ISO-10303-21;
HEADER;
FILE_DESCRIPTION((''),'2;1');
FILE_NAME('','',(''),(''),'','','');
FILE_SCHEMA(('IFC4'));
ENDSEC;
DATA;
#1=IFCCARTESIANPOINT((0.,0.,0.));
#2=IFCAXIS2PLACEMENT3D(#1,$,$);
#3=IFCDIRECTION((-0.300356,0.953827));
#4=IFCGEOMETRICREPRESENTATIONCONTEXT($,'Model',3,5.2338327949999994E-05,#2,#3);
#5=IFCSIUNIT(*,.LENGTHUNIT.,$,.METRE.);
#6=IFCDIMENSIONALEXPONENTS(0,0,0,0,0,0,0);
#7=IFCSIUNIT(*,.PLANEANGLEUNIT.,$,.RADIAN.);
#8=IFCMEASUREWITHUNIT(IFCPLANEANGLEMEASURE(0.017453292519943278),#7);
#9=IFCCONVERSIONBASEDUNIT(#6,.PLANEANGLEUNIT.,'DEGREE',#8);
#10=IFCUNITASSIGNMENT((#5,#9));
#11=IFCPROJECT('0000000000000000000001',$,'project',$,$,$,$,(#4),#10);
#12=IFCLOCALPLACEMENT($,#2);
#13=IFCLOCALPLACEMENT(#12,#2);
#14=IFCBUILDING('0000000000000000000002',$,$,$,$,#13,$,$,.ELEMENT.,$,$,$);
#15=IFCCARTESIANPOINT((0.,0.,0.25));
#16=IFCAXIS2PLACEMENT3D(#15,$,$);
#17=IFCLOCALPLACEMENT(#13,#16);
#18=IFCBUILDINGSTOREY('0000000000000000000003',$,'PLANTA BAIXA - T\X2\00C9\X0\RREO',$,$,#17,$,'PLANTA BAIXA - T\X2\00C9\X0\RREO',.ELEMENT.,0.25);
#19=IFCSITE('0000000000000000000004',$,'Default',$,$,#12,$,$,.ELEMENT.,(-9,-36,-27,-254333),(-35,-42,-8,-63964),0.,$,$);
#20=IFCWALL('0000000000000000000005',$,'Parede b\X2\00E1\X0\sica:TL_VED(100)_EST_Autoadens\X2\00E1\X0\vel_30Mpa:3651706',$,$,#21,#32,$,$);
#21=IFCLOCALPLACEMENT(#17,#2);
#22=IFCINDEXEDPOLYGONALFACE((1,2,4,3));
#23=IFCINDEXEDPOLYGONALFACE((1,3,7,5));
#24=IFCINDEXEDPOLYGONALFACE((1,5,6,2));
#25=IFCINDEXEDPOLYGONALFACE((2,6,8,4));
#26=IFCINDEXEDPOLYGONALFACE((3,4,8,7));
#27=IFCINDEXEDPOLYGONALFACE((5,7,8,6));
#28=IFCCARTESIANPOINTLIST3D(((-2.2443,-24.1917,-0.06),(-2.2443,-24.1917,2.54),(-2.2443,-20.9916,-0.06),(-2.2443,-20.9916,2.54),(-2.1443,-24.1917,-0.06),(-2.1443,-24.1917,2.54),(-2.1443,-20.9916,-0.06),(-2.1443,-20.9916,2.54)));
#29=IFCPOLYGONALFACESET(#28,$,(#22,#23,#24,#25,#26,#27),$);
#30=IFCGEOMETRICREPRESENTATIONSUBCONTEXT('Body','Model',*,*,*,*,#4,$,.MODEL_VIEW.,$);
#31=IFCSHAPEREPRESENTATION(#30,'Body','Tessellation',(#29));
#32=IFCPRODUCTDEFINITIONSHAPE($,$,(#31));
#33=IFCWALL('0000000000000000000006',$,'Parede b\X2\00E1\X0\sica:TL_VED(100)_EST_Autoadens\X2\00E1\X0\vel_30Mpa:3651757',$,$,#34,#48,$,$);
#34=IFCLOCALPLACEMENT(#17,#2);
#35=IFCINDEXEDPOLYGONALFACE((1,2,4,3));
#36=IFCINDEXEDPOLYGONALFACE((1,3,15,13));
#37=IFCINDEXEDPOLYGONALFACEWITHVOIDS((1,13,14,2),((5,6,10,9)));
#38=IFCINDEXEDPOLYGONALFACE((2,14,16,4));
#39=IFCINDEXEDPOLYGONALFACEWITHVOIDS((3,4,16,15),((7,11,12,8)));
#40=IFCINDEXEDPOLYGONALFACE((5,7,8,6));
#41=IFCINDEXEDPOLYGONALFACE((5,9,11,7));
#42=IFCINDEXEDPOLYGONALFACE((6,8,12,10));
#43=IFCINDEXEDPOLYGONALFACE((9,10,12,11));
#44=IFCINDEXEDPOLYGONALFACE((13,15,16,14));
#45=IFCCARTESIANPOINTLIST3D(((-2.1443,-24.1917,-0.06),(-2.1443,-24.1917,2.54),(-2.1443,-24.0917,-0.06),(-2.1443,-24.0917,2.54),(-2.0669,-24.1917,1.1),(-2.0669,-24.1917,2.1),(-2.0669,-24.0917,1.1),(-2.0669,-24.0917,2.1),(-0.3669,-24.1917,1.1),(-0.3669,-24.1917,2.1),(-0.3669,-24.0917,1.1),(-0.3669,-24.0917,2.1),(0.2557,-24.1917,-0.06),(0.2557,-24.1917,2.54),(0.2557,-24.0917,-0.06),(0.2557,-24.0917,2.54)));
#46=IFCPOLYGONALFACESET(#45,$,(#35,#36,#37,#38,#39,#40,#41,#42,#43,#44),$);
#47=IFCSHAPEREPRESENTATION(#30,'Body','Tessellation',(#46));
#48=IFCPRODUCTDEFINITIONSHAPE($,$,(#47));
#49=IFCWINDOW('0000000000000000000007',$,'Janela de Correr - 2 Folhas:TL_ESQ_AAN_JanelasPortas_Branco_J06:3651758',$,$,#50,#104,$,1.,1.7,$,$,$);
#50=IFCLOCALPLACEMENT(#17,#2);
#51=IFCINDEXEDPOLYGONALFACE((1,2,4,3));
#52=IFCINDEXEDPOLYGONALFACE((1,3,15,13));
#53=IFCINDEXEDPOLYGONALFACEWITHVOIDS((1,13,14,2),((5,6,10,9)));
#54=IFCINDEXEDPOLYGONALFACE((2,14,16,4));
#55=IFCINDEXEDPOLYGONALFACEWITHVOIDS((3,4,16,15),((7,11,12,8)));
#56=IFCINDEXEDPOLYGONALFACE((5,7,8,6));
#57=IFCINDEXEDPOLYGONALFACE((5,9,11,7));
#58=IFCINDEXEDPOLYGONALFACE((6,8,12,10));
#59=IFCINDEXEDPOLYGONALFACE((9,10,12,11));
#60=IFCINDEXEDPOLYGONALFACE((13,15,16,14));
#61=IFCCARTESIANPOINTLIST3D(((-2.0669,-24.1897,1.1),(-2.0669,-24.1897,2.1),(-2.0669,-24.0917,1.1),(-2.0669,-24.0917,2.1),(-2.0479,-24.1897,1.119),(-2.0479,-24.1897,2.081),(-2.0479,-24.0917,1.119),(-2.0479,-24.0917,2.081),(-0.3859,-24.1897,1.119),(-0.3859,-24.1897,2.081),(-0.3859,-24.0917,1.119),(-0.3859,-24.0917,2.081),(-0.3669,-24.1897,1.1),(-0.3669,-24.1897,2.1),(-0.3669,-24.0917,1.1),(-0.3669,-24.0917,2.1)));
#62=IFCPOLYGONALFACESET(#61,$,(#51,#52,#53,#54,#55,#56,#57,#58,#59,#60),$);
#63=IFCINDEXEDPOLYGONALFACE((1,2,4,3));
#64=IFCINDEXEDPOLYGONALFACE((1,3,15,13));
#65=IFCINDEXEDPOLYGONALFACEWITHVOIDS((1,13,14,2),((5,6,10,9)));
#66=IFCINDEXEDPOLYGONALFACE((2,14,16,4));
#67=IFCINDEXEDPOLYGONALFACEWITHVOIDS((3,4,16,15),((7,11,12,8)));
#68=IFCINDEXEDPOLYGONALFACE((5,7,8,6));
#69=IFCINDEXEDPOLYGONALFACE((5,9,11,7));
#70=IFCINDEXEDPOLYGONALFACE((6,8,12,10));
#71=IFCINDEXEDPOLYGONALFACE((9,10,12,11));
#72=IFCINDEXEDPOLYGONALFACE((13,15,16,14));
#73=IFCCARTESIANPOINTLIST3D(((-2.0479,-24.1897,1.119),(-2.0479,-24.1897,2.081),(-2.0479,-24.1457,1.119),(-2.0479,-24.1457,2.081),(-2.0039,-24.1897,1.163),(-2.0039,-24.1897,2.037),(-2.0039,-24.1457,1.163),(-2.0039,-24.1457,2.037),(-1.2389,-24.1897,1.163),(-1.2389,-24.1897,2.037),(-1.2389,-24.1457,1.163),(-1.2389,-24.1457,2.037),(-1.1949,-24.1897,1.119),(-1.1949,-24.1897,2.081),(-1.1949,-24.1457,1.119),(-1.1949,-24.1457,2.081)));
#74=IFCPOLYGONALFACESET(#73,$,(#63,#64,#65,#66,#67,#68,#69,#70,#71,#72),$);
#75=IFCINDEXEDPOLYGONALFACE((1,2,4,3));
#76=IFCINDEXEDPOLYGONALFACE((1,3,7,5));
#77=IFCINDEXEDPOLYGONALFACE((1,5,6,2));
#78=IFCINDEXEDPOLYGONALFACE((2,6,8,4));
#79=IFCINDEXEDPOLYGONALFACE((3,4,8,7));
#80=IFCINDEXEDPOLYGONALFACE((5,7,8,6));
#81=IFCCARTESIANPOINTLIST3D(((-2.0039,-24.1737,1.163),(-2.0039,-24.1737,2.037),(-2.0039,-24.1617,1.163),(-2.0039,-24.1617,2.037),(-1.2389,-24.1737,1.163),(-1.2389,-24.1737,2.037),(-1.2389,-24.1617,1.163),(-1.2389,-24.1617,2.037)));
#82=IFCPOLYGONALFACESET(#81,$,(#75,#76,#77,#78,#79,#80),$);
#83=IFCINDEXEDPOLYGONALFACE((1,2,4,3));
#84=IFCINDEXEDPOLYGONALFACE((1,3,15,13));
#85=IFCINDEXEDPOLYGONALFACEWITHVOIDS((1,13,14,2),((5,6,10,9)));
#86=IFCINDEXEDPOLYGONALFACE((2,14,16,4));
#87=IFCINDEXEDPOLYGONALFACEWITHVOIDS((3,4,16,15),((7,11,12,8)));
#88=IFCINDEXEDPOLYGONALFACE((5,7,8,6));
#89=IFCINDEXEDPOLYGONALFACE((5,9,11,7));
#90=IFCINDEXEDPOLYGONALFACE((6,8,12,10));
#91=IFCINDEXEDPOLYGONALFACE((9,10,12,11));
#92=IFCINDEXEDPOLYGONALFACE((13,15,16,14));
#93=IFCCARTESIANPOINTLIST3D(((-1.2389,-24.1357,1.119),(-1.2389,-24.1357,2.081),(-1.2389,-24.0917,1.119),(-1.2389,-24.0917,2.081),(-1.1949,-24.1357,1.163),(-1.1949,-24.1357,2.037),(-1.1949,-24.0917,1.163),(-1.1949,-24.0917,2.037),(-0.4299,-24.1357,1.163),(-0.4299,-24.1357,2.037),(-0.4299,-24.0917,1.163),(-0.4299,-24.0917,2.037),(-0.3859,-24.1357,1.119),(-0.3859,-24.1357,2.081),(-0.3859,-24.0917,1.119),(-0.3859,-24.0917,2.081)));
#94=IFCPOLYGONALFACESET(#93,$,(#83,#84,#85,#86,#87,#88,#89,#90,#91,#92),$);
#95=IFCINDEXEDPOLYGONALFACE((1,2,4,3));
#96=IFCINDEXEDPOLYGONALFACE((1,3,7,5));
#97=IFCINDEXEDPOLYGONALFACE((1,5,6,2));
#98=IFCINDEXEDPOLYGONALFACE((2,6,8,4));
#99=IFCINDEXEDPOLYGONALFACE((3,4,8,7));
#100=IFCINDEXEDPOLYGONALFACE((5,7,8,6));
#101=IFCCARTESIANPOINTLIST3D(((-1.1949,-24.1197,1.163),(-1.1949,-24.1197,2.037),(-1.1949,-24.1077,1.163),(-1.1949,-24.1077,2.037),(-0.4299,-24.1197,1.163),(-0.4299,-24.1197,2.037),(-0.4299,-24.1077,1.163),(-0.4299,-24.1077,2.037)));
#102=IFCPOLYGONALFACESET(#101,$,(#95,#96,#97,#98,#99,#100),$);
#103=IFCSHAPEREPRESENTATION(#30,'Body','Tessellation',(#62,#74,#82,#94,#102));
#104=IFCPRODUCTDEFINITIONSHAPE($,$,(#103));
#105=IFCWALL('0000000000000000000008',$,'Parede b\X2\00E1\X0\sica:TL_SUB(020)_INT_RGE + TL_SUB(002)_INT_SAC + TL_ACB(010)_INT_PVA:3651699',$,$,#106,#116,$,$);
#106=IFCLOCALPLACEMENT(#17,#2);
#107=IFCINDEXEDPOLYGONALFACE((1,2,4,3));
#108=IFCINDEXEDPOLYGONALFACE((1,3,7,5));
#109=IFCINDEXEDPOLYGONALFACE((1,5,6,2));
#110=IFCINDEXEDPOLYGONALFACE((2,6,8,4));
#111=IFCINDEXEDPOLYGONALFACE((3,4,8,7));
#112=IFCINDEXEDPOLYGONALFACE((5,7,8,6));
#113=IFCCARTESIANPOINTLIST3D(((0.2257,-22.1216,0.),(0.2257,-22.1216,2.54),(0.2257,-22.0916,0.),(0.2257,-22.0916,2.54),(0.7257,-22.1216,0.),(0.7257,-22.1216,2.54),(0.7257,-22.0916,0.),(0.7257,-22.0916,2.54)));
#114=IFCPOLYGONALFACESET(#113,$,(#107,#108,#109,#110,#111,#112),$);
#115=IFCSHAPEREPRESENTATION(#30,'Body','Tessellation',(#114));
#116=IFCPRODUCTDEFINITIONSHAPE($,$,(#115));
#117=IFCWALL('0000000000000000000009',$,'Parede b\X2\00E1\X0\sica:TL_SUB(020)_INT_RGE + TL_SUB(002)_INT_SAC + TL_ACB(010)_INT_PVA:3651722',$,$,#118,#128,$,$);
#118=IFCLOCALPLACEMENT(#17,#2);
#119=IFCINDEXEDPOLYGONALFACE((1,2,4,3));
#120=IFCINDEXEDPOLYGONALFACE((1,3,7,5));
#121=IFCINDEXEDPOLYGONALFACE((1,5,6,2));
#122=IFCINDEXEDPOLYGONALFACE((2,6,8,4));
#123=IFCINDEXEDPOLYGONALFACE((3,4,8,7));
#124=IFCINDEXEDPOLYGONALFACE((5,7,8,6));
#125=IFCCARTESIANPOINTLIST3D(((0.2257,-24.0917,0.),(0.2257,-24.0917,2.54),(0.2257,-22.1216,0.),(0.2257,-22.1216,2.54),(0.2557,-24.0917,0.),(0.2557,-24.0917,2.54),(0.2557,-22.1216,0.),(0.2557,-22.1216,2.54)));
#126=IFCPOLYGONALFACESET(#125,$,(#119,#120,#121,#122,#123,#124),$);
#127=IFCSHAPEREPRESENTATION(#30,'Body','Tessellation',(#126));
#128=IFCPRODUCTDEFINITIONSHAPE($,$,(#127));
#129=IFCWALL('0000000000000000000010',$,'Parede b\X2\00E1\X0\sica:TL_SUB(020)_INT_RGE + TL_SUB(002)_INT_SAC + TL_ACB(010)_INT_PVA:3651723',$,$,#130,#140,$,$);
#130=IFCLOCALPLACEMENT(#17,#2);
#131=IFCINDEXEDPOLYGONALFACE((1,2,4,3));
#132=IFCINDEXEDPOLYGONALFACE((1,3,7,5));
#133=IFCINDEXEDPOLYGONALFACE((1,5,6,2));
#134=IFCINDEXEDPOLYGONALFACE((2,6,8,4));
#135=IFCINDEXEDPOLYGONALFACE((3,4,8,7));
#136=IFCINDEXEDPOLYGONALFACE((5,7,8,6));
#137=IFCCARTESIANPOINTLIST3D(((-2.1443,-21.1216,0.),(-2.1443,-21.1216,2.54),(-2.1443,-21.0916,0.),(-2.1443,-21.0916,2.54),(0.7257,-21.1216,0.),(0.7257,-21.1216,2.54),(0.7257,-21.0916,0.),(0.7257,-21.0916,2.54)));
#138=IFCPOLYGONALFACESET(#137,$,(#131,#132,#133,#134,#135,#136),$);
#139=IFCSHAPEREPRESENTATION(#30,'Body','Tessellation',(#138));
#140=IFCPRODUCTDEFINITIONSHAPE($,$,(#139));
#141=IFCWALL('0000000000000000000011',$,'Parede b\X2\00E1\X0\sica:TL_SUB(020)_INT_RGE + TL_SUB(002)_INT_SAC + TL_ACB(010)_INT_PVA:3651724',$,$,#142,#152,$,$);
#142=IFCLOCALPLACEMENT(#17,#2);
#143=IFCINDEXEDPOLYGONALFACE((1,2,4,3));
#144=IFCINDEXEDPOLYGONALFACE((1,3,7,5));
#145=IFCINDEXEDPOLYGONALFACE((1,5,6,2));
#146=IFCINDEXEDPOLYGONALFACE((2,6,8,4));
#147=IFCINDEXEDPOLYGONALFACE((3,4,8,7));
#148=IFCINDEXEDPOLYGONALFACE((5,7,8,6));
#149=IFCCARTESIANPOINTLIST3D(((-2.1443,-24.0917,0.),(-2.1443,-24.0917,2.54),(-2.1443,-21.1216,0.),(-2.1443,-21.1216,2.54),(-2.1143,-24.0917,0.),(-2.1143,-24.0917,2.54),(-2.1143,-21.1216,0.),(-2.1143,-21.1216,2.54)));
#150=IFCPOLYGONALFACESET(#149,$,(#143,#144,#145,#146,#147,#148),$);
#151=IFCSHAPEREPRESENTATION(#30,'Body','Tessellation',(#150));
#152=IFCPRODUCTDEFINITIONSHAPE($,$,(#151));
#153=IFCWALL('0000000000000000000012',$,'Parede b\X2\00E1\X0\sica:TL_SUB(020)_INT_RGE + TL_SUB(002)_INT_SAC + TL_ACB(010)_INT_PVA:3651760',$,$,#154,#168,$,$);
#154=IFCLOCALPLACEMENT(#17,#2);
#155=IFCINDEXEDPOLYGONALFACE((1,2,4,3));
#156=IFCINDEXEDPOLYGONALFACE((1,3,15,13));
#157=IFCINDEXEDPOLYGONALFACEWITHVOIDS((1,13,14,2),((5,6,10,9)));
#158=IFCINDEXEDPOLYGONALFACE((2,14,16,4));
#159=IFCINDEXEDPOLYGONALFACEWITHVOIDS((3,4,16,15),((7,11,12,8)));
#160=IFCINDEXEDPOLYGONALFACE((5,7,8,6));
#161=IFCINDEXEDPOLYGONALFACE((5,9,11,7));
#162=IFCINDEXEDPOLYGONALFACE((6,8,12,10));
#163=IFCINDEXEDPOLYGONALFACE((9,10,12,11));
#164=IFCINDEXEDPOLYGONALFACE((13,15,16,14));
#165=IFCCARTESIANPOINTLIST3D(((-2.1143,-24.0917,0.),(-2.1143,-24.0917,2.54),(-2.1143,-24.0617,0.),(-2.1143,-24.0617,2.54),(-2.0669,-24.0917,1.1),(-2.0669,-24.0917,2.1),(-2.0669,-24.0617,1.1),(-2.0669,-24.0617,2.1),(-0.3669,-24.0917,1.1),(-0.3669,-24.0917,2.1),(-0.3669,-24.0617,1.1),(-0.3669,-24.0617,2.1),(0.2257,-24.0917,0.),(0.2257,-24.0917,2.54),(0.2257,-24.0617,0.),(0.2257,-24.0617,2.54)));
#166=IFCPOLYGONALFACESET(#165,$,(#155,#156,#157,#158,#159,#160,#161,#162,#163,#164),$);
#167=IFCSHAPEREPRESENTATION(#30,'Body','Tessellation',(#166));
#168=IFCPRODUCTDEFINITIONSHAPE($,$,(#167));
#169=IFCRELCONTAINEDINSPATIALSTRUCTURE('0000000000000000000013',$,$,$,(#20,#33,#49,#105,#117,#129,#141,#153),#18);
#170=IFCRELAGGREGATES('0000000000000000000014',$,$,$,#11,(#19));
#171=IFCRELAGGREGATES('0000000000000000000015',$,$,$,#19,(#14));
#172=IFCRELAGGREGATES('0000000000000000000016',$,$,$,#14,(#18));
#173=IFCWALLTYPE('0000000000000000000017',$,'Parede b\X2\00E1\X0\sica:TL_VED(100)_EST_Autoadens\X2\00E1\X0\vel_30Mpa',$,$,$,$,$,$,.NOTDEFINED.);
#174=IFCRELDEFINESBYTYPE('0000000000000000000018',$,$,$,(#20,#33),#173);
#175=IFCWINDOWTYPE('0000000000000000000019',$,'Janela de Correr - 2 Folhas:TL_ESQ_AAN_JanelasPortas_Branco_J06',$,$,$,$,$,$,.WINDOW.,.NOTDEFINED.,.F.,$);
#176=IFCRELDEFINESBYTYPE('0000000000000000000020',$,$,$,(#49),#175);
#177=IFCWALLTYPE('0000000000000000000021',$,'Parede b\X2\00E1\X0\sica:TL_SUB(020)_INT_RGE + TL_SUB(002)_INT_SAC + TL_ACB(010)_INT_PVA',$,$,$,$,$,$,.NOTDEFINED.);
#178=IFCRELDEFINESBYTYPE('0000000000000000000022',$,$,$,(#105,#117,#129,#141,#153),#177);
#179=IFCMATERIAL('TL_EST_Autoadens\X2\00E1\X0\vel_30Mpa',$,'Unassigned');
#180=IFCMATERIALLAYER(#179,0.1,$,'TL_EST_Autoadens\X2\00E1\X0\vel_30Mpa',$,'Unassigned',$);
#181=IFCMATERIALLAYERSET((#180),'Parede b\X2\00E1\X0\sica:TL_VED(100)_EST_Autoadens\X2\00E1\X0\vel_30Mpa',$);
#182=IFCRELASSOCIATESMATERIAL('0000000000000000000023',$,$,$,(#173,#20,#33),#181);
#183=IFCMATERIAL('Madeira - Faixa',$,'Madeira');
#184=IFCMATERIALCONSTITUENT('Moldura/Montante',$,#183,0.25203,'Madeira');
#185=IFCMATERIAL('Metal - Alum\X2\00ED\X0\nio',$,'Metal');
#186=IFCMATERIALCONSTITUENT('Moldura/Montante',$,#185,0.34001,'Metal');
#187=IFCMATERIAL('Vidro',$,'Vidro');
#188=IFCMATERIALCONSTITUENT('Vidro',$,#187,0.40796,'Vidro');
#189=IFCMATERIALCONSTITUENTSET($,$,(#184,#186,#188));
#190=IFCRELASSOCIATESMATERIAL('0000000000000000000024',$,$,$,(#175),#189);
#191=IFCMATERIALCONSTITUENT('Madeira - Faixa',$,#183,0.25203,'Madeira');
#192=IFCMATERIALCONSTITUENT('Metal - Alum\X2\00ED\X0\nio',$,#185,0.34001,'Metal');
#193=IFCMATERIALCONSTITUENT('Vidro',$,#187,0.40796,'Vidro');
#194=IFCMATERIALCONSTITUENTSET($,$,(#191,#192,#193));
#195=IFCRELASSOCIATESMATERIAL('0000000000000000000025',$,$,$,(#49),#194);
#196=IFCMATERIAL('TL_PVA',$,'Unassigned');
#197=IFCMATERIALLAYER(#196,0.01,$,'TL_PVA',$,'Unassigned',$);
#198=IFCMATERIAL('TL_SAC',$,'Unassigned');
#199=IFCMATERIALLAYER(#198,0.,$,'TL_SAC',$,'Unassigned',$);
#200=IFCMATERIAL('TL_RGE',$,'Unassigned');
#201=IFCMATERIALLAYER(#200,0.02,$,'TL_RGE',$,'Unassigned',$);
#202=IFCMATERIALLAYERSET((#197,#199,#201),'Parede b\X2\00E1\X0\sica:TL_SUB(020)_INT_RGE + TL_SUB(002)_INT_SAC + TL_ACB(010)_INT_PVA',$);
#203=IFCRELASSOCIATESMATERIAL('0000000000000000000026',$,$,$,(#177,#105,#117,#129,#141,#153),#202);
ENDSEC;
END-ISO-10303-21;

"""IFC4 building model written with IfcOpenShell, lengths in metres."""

from ifc_helpers import new_model, entity, si_unit, converted_unit, direction, frame, frame_2d, origin, origin_2d_with_axis, place, context, subcontext, project, spatial, polyline, rectangle, outline, extrude, source, transform, mapped, material, layer, layer_set, layer_usage, constituent, constituent_set, type_object, type_shapes, element, fill, save


model = new_model("IFC4")

# Units and contexts
model_context = context("Model", 3, precision=5.2338327949999994e-05, world=origin(), true_north=direction((-0.300356, 0.953827)))
body_context = subcontext(model_context, "Body", "Model", "MODEL_VIEW")
ifc_project = project(units=[si_unit("LENGTHUNIT", "METRE"), converted_unit("PLANEANGLEUNIT", "DEGREE", entity("IfcPlaneAngleMeasure", 0.017453292519943278), si_unit("PLANEANGLEUNIT", "RADIAN"), dimensions=[0, 0, 0, 0, 0, 0, 0])], contexts=[model_context])

# Site, building, storey
site_placement = place(None, origin())
site = spatial("IfcSite", under=ifc_project, at=site_placement, Name="Default", CompositionType="ELEMENT", RefLatitude=(-9, -36, -27, -254333), RefLongitude=(-35, -42, -8, -63964), RefElevation=0.0)
building_placement = place(site_placement, origin())
building = spatial("IfcBuilding", under=site, at=building_placement, CompositionType="ELEMENT")
storey_placement = place(building_placement, frame((0.0, 0.0, 0.25)))
storey = spatial("IfcBuildingStorey", under=building, at=storey_placement, Name="PLANTA BAIXA - TÉRREO", LongName="PLANTA BAIXA - TÉRREO", CompositionType="ELEMENT", Elevation=0.25)

# Wall
ifc_material_1 = material(Name="TL_EST_Autoadensável_30Mpa", Category="Unassigned")
ifc_layer_1 = layer(ifc_material_1, 0.1, Name="TL_EST_Autoadensável_30Mpa", Category="Unassigned")
ifc_layer_set_1 = layer_set([ifc_layer_1], Name="Parede básica:TL_VED(100)_EST_Autoadensável_30Mpa")
ifc_layer_usage_1 = layer_usage(ifc_layer_set_1, "AXIS2", "POSITIVE", -0.05)
wall_type_1 = type_object("IfcWallType", Name="Parede básica:TL_VED(100)_EST_Autoadensável_30Mpa", PredefinedType="NOTDEFINED", material=ifc_layer_set_1)
wall_1_placement = place(storey_placement, frame((-2.1943, -24.1917, -0.06), z_axis=(0.0, 0.0, 1.0), x_axis=(0.0, 1.0, 0.0)))
element("IfcWall", 1, at=wall_1_placement, inside=storey, type_object=wall_type_1, material=ifc_layer_usage_1, Name="Parede básica:TL_VED(100)_EST_Autoadensável_30Mpa:3651706", context=body_context, shape_type="SweptSolid", body=[
    extrude(rectangle(XDim=3.2001, YDim=0.1, at=frame_2d((1.6001, 0.0), x_axis=(-1.0, 0.0))), origin(), (0.0, 0.0, 1.0), 2.6),
])

# Wall, opening, window
ifc_layer_usage_2 = layer_usage(ifc_layer_set_1, "AXIS2", "POSITIVE", -0.05)
wall_2_placement = place(storey_placement, frame((-2.1443, -24.1417, -0.06)))
wall_2 = element("IfcWall", 2, at=wall_2_placement, inside=storey, type_object=wall_type_1, material=ifc_layer_usage_2, Name="Parede básica:TL_VED(100)_EST_Autoadensável_30Mpa:3651757", context=body_context, shape_type="SweptSolid", body=[
    extrude(rectangle(XDim=2.4, YDim=0.1, at=frame_2d((1.2, 0.0), x_axis=(-1.0, 0.0))), origin(), (0.0, 0.0, 1.0), 2.6),
])
opening_1_placement = place(wall_2_placement, frame((1.7774, 0.05, 1.16)))
opening_1 = element("IfcOpeningElement", 3, at=opening_1_placement, cuts=wall_2, PredefinedType="OPENING", context=body_context, shape_type="SweptSolid", body=[
    extrude(rectangle(XDim=1.0, YDim=1.7, at=frame_2d((0.5, 0.85), x_axis=(-1.0, 0.0))), frame((0.0, 0.0, 0.0), z_axis=(0.0, -1.0, 0.0), x_axis=(0.0, 0.0, 1.0)), (0.0, 0.0, 1.0), 0.1),
])
ifc_material_2 = material(Name="Madeira - Faixa", Category="Madeira")
ifc_constituent_1 = constituent(ifc_material_2, Name="Madeira - Faixa", Category="Madeira", fraction=0.25203)
ifc_material_3 = material(Name="Metal - Alumínio", Category="Metal")
ifc_constituent_2 = constituent(ifc_material_3, Name="Metal - Alumínio", Category="Metal", fraction=0.34001)
ifc_material_4 = material(Name="Vidro", Category="Vidro")
ifc_constituent_3 = constituent(ifc_material_4, Name="Vidro", Category="Vidro", fraction=0.40796)
ifc_constituent_set_1 = constituent_set(constituents=[ifc_constituent_1, ifc_constituent_2, ifc_constituent_3])
ifc_constituent_4 = constituent(ifc_material_2, Name="Moldura/Montante", Category="Madeira", fraction=0.25203)
ifc_constituent_5 = constituent(ifc_material_3, Name="Moldura/Montante", Category="Metal", fraction=0.34001)
ifc_constituent_6 = constituent(ifc_material_4, Name="Vidro", Category="Vidro", fraction=0.40796)
ifc_constituent_set_2 = constituent_set(constituents=[ifc_constituent_4, ifc_constituent_5, ifc_constituent_6])
window_type = type_object("IfcWindowType", Name="Janela de Correr - 2 Folhas:TL_ESQ_AAN_JanelasPortas_Branco_J06", ParameterTakesPrecedence=False, PartitioningType="NOTDEFINED", PredefinedType="WINDOW", material=ifc_constituent_set_2)
shared_shape_1 = source(origin(), body_context, "Body", "SweptSolid", [
    extrude(outline(polyline([(-0.85, -0.5), (0.85, -0.5), (0.85, 0.5), (-0.85, 0.5), (-0.85, -0.5)]), holes=[polyline([(-0.831, -0.481), (-0.831, 0.481), (0.831, 0.481), (0.831, -0.481), (-0.831, -0.481)])]), frame((0.85, 0.0, 0.5), z_axis=(0.0, 1.0, 0.0), x_axis=(1.0, 0.0, 0.0)), (0.0, 0.0, 1.0), 0.098),
    extrude(outline(polyline([(-0.4265, -0.481), (0.4265, -0.481), (0.4265, 0.481), (-0.4265, 0.481), (-0.4265, -0.481)]), holes=[polyline([(-0.3825, -0.437), (-0.3825, 0.437), (0.3825, 0.437), (0.3825, -0.437), (-0.3825, -0.437)])]), frame((1.2545, 0.054, 0.5), z_axis=(0.0, 1.0, 0.0), x_axis=(1.0, 0.0, 0.0)), (0.0, 0.0, 1.0), 0.044),
    extrude(rectangle(XDim=0.012, YDim=0.765, at=origin_2d_with_axis()), frame((1.2545, 0.076, 0.063), z_axis=(0.0, 0.0, 1.0), x_axis=(0.0, -1.0, 0.0)), (0.0, 0.0, 1.0), 0.874),
    extrude(outline(polyline([(-0.481, -0.4265), (0.481, -0.4265), (0.481, 0.4265), (-0.481, 0.4265), (-0.481, -0.4265)]), holes=[polyline([(-0.437, -0.3825), (-0.437, 0.3825), (0.437, 0.3825), (0.437, -0.3825), (-0.437, -0.3825)])]), frame((0.4455, 0.0, 0.5), z_axis=(0.0, 1.0, 0.0), x_axis=(0.0, 0.0, -1.0)), (0.0, 0.0, 1.0), 0.044),
    extrude(rectangle(XDim=0.012, YDim=0.765, at=origin_2d_with_axis()), frame((0.4455, 0.022, 0.063), z_axis=(0.0, 0.0, 1.0), x_axis=(0.0, -1.0, 0.0)), (0.0, 0.0, 1.0), 0.874),
])
type_shapes(window_type, [shared_shape_1])
window_placement = place(opening_1_placement, frame((0.0, 0.0, 0.0), z_axis=(0.0, 0.0, 1.0), x_axis=(-1.0, 0.0, 0.0)))
window = element("IfcWindow", 4, at=window_placement, inside=storey, type_object=window_type, material=ifc_constituent_set_1, Name="Janela de Correr - 2 Folhas:TL_ESQ_AAN_JanelasPortas_Branco_J06:3651758", OverallHeight=1.0, OverallWidth=1.7, context=body_context, shape_type="MappedRepresentation", body=[
    mapped(shared_shape_1, transform((0.0, 0.0, 0.0), scale=1.0)),
])
fill(opening_1, window)

# Walls
ifc_material_5 = material(Name="TL_PVA", Category="Unassigned")
ifc_layer_2 = layer(ifc_material_5, 0.01, Name="TL_PVA", Category="Unassigned")
ifc_material_6 = material(Name="TL_SAC", Category="Unassigned")
ifc_layer_3 = layer(ifc_material_6, 0.0, Name="TL_SAC", Category="Unassigned")
ifc_material_7 = material(Name="TL_RGE", Category="Unassigned")
ifc_layer_4 = layer(ifc_material_7, 0.02, Name="TL_RGE", Category="Unassigned")
ifc_layer_set_2 = layer_set([ifc_layer_2, ifc_layer_3, ifc_layer_4], Name="Parede básica:TL_SUB(020)_INT_RGE + TL_SUB(002)_INT_SAC + TL_ACB(010)_INT_PVA")
ifc_layer_usage_3 = layer_usage(ifc_layer_set_2, "AXIS2", "NEGATIVE", 0.015)
wall_type_2 = type_object("IfcWallType", Name="Parede básica:TL_SUB(020)_INT_RGE + TL_SUB(002)_INT_SAC + TL_ACB(010)_INT_PVA", PredefinedType="NOTDEFINED", material=ifc_layer_set_2)
wall_3_placement = place(storey_placement, frame((0.2257, -22.1066, 0.0)))
element("IfcWall", 5, at=wall_3_placement, inside=storey, type_object=wall_type_2, material=ifc_layer_usage_3, Name="Parede básica:TL_SUB(020)_INT_RGE + TL_SUB(002)_INT_SAC + TL_ACB(010)_INT_PVA:3651699", context=body_context, shape_type="SweptSolid", body=[
    extrude(rectangle(XDim=0.5, YDim=0.03, at=frame_2d((0.25, 0.0), x_axis=(-1.0, 0.0))), origin(), (0.0, 0.0, 1.0), 2.54),
])
ifc_layer_usage_4 = layer_usage(ifc_layer_set_2, "AXIS2", "POSITIVE", -0.015)
wall_4_placement = place(storey_placement, frame((0.2407, -22.1216, 0.0), z_axis=(0.0, 0.0, 1.0), x_axis=(0.0, -1.0, 0.0)))
element("IfcWall", 6, at=wall_4_placement, inside=storey, type_object=wall_type_2, material=ifc_layer_usage_4, Name="Parede básica:TL_SUB(020)_INT_RGE + TL_SUB(002)_INT_SAC + TL_ACB(010)_INT_PVA:3651722", context=body_context, shape_type="SweptSolid", body=[
    extrude(rectangle(XDim=1.9701, YDim=0.03, at=frame_2d((0.9851, 0.0), x_axis=(-1.0, 0.0))), origin(), (0.0, 0.0, 1.0), 2.54),
])
ifc_layer_usage_5 = layer_usage(ifc_layer_set_2, "AXIS2", "POSITIVE", -0.015)
wall_5_placement = place(storey_placement, frame((-2.1443, -21.1066, 0.0)))
element("IfcWall", 7, at=wall_5_placement, inside=storey, type_object=wall_type_2, material=ifc_layer_usage_5, Name="Parede básica:TL_SUB(020)_INT_RGE + TL_SUB(002)_INT_SAC + TL_ACB(010)_INT_PVA:3651723", context=body_context, shape_type="SweptSolid", body=[
    extrude(rectangle(XDim=2.87, YDim=0.03, at=frame_2d((1.435, 0.0), x_axis=(-1.0, 0.0))), origin(), (0.0, 0.0, 1.0), 2.54),
])
ifc_layer_usage_6 = layer_usage(ifc_layer_set_2, "AXIS2", "POSITIVE", -0.015)
wall_6_placement = place(storey_placement, frame((-2.1293, -24.0917, 0.0), z_axis=(0.0, 0.0, 1.0), x_axis=(0.0, 1.0, 0.0)))
element("IfcWall", 8, at=wall_6_placement, inside=storey, type_object=wall_type_2, material=ifc_layer_usage_6, Name="Parede básica:TL_SUB(020)_INT_RGE + TL_SUB(002)_INT_SAC + TL_ACB(010)_INT_PVA:3651724", context=body_context, shape_type="SweptSolid", body=[
    extrude(rectangle(XDim=2.9701, YDim=0.03, at=frame_2d((1.4851, 0.0), x_axis=(-1.0, 0.0))), origin(), (0.0, 0.0, 1.0), 2.54),
])

# Wall, opening
ifc_layer_usage_7 = layer_usage(ifc_layer_set_2, "AXIS2", "POSITIVE", -0.015)
wall_7_placement = place(storey_placement, frame((0.2257, -24.0767, 0.0), z_axis=(0.0, 0.0, 1.0), x_axis=(-1.0, 0.0, 0.0)))
wall_7 = element("IfcWall", 9, at=wall_7_placement, inside=storey, type_object=wall_type_2, material=ifc_layer_usage_7, Name="Parede básica:TL_SUB(020)_INT_RGE + TL_SUB(002)_INT_SAC + TL_ACB(010)_INT_PVA:3651760", context=body_context, shape_type="SweptSolid", body=[
    extrude(rectangle(XDim=2.34, YDim=0.03, at=frame_2d((1.17, 0.0), x_axis=(-1.0, 0.0))), origin(), (0.0, 0.0, 1.0), 2.54),
])
opening_2_placement = place(wall_7_placement, frame((0.2257, -24.0767, 1.1)))
element("IfcOpeningElement", 10, at=opening_2_placement, cuts=wall_7, PredefinedType="OPENING", context=body_context, shape_type="SweptSolid", body=[
    extrude(rectangle(XDim=1.0, YDim=1.7, at=frame_2d((0.0, 0.0), x_axis=(0.0, 1.0))), frame((1.2169, 22.5677, 0.5), z_axis=(0.0, 1.0, 0.0), x_axis=(1.0, 0.0, 0.0)), (0.0, 0.0, 1.0), 3.048),
])

save(model, "model.ifc")
